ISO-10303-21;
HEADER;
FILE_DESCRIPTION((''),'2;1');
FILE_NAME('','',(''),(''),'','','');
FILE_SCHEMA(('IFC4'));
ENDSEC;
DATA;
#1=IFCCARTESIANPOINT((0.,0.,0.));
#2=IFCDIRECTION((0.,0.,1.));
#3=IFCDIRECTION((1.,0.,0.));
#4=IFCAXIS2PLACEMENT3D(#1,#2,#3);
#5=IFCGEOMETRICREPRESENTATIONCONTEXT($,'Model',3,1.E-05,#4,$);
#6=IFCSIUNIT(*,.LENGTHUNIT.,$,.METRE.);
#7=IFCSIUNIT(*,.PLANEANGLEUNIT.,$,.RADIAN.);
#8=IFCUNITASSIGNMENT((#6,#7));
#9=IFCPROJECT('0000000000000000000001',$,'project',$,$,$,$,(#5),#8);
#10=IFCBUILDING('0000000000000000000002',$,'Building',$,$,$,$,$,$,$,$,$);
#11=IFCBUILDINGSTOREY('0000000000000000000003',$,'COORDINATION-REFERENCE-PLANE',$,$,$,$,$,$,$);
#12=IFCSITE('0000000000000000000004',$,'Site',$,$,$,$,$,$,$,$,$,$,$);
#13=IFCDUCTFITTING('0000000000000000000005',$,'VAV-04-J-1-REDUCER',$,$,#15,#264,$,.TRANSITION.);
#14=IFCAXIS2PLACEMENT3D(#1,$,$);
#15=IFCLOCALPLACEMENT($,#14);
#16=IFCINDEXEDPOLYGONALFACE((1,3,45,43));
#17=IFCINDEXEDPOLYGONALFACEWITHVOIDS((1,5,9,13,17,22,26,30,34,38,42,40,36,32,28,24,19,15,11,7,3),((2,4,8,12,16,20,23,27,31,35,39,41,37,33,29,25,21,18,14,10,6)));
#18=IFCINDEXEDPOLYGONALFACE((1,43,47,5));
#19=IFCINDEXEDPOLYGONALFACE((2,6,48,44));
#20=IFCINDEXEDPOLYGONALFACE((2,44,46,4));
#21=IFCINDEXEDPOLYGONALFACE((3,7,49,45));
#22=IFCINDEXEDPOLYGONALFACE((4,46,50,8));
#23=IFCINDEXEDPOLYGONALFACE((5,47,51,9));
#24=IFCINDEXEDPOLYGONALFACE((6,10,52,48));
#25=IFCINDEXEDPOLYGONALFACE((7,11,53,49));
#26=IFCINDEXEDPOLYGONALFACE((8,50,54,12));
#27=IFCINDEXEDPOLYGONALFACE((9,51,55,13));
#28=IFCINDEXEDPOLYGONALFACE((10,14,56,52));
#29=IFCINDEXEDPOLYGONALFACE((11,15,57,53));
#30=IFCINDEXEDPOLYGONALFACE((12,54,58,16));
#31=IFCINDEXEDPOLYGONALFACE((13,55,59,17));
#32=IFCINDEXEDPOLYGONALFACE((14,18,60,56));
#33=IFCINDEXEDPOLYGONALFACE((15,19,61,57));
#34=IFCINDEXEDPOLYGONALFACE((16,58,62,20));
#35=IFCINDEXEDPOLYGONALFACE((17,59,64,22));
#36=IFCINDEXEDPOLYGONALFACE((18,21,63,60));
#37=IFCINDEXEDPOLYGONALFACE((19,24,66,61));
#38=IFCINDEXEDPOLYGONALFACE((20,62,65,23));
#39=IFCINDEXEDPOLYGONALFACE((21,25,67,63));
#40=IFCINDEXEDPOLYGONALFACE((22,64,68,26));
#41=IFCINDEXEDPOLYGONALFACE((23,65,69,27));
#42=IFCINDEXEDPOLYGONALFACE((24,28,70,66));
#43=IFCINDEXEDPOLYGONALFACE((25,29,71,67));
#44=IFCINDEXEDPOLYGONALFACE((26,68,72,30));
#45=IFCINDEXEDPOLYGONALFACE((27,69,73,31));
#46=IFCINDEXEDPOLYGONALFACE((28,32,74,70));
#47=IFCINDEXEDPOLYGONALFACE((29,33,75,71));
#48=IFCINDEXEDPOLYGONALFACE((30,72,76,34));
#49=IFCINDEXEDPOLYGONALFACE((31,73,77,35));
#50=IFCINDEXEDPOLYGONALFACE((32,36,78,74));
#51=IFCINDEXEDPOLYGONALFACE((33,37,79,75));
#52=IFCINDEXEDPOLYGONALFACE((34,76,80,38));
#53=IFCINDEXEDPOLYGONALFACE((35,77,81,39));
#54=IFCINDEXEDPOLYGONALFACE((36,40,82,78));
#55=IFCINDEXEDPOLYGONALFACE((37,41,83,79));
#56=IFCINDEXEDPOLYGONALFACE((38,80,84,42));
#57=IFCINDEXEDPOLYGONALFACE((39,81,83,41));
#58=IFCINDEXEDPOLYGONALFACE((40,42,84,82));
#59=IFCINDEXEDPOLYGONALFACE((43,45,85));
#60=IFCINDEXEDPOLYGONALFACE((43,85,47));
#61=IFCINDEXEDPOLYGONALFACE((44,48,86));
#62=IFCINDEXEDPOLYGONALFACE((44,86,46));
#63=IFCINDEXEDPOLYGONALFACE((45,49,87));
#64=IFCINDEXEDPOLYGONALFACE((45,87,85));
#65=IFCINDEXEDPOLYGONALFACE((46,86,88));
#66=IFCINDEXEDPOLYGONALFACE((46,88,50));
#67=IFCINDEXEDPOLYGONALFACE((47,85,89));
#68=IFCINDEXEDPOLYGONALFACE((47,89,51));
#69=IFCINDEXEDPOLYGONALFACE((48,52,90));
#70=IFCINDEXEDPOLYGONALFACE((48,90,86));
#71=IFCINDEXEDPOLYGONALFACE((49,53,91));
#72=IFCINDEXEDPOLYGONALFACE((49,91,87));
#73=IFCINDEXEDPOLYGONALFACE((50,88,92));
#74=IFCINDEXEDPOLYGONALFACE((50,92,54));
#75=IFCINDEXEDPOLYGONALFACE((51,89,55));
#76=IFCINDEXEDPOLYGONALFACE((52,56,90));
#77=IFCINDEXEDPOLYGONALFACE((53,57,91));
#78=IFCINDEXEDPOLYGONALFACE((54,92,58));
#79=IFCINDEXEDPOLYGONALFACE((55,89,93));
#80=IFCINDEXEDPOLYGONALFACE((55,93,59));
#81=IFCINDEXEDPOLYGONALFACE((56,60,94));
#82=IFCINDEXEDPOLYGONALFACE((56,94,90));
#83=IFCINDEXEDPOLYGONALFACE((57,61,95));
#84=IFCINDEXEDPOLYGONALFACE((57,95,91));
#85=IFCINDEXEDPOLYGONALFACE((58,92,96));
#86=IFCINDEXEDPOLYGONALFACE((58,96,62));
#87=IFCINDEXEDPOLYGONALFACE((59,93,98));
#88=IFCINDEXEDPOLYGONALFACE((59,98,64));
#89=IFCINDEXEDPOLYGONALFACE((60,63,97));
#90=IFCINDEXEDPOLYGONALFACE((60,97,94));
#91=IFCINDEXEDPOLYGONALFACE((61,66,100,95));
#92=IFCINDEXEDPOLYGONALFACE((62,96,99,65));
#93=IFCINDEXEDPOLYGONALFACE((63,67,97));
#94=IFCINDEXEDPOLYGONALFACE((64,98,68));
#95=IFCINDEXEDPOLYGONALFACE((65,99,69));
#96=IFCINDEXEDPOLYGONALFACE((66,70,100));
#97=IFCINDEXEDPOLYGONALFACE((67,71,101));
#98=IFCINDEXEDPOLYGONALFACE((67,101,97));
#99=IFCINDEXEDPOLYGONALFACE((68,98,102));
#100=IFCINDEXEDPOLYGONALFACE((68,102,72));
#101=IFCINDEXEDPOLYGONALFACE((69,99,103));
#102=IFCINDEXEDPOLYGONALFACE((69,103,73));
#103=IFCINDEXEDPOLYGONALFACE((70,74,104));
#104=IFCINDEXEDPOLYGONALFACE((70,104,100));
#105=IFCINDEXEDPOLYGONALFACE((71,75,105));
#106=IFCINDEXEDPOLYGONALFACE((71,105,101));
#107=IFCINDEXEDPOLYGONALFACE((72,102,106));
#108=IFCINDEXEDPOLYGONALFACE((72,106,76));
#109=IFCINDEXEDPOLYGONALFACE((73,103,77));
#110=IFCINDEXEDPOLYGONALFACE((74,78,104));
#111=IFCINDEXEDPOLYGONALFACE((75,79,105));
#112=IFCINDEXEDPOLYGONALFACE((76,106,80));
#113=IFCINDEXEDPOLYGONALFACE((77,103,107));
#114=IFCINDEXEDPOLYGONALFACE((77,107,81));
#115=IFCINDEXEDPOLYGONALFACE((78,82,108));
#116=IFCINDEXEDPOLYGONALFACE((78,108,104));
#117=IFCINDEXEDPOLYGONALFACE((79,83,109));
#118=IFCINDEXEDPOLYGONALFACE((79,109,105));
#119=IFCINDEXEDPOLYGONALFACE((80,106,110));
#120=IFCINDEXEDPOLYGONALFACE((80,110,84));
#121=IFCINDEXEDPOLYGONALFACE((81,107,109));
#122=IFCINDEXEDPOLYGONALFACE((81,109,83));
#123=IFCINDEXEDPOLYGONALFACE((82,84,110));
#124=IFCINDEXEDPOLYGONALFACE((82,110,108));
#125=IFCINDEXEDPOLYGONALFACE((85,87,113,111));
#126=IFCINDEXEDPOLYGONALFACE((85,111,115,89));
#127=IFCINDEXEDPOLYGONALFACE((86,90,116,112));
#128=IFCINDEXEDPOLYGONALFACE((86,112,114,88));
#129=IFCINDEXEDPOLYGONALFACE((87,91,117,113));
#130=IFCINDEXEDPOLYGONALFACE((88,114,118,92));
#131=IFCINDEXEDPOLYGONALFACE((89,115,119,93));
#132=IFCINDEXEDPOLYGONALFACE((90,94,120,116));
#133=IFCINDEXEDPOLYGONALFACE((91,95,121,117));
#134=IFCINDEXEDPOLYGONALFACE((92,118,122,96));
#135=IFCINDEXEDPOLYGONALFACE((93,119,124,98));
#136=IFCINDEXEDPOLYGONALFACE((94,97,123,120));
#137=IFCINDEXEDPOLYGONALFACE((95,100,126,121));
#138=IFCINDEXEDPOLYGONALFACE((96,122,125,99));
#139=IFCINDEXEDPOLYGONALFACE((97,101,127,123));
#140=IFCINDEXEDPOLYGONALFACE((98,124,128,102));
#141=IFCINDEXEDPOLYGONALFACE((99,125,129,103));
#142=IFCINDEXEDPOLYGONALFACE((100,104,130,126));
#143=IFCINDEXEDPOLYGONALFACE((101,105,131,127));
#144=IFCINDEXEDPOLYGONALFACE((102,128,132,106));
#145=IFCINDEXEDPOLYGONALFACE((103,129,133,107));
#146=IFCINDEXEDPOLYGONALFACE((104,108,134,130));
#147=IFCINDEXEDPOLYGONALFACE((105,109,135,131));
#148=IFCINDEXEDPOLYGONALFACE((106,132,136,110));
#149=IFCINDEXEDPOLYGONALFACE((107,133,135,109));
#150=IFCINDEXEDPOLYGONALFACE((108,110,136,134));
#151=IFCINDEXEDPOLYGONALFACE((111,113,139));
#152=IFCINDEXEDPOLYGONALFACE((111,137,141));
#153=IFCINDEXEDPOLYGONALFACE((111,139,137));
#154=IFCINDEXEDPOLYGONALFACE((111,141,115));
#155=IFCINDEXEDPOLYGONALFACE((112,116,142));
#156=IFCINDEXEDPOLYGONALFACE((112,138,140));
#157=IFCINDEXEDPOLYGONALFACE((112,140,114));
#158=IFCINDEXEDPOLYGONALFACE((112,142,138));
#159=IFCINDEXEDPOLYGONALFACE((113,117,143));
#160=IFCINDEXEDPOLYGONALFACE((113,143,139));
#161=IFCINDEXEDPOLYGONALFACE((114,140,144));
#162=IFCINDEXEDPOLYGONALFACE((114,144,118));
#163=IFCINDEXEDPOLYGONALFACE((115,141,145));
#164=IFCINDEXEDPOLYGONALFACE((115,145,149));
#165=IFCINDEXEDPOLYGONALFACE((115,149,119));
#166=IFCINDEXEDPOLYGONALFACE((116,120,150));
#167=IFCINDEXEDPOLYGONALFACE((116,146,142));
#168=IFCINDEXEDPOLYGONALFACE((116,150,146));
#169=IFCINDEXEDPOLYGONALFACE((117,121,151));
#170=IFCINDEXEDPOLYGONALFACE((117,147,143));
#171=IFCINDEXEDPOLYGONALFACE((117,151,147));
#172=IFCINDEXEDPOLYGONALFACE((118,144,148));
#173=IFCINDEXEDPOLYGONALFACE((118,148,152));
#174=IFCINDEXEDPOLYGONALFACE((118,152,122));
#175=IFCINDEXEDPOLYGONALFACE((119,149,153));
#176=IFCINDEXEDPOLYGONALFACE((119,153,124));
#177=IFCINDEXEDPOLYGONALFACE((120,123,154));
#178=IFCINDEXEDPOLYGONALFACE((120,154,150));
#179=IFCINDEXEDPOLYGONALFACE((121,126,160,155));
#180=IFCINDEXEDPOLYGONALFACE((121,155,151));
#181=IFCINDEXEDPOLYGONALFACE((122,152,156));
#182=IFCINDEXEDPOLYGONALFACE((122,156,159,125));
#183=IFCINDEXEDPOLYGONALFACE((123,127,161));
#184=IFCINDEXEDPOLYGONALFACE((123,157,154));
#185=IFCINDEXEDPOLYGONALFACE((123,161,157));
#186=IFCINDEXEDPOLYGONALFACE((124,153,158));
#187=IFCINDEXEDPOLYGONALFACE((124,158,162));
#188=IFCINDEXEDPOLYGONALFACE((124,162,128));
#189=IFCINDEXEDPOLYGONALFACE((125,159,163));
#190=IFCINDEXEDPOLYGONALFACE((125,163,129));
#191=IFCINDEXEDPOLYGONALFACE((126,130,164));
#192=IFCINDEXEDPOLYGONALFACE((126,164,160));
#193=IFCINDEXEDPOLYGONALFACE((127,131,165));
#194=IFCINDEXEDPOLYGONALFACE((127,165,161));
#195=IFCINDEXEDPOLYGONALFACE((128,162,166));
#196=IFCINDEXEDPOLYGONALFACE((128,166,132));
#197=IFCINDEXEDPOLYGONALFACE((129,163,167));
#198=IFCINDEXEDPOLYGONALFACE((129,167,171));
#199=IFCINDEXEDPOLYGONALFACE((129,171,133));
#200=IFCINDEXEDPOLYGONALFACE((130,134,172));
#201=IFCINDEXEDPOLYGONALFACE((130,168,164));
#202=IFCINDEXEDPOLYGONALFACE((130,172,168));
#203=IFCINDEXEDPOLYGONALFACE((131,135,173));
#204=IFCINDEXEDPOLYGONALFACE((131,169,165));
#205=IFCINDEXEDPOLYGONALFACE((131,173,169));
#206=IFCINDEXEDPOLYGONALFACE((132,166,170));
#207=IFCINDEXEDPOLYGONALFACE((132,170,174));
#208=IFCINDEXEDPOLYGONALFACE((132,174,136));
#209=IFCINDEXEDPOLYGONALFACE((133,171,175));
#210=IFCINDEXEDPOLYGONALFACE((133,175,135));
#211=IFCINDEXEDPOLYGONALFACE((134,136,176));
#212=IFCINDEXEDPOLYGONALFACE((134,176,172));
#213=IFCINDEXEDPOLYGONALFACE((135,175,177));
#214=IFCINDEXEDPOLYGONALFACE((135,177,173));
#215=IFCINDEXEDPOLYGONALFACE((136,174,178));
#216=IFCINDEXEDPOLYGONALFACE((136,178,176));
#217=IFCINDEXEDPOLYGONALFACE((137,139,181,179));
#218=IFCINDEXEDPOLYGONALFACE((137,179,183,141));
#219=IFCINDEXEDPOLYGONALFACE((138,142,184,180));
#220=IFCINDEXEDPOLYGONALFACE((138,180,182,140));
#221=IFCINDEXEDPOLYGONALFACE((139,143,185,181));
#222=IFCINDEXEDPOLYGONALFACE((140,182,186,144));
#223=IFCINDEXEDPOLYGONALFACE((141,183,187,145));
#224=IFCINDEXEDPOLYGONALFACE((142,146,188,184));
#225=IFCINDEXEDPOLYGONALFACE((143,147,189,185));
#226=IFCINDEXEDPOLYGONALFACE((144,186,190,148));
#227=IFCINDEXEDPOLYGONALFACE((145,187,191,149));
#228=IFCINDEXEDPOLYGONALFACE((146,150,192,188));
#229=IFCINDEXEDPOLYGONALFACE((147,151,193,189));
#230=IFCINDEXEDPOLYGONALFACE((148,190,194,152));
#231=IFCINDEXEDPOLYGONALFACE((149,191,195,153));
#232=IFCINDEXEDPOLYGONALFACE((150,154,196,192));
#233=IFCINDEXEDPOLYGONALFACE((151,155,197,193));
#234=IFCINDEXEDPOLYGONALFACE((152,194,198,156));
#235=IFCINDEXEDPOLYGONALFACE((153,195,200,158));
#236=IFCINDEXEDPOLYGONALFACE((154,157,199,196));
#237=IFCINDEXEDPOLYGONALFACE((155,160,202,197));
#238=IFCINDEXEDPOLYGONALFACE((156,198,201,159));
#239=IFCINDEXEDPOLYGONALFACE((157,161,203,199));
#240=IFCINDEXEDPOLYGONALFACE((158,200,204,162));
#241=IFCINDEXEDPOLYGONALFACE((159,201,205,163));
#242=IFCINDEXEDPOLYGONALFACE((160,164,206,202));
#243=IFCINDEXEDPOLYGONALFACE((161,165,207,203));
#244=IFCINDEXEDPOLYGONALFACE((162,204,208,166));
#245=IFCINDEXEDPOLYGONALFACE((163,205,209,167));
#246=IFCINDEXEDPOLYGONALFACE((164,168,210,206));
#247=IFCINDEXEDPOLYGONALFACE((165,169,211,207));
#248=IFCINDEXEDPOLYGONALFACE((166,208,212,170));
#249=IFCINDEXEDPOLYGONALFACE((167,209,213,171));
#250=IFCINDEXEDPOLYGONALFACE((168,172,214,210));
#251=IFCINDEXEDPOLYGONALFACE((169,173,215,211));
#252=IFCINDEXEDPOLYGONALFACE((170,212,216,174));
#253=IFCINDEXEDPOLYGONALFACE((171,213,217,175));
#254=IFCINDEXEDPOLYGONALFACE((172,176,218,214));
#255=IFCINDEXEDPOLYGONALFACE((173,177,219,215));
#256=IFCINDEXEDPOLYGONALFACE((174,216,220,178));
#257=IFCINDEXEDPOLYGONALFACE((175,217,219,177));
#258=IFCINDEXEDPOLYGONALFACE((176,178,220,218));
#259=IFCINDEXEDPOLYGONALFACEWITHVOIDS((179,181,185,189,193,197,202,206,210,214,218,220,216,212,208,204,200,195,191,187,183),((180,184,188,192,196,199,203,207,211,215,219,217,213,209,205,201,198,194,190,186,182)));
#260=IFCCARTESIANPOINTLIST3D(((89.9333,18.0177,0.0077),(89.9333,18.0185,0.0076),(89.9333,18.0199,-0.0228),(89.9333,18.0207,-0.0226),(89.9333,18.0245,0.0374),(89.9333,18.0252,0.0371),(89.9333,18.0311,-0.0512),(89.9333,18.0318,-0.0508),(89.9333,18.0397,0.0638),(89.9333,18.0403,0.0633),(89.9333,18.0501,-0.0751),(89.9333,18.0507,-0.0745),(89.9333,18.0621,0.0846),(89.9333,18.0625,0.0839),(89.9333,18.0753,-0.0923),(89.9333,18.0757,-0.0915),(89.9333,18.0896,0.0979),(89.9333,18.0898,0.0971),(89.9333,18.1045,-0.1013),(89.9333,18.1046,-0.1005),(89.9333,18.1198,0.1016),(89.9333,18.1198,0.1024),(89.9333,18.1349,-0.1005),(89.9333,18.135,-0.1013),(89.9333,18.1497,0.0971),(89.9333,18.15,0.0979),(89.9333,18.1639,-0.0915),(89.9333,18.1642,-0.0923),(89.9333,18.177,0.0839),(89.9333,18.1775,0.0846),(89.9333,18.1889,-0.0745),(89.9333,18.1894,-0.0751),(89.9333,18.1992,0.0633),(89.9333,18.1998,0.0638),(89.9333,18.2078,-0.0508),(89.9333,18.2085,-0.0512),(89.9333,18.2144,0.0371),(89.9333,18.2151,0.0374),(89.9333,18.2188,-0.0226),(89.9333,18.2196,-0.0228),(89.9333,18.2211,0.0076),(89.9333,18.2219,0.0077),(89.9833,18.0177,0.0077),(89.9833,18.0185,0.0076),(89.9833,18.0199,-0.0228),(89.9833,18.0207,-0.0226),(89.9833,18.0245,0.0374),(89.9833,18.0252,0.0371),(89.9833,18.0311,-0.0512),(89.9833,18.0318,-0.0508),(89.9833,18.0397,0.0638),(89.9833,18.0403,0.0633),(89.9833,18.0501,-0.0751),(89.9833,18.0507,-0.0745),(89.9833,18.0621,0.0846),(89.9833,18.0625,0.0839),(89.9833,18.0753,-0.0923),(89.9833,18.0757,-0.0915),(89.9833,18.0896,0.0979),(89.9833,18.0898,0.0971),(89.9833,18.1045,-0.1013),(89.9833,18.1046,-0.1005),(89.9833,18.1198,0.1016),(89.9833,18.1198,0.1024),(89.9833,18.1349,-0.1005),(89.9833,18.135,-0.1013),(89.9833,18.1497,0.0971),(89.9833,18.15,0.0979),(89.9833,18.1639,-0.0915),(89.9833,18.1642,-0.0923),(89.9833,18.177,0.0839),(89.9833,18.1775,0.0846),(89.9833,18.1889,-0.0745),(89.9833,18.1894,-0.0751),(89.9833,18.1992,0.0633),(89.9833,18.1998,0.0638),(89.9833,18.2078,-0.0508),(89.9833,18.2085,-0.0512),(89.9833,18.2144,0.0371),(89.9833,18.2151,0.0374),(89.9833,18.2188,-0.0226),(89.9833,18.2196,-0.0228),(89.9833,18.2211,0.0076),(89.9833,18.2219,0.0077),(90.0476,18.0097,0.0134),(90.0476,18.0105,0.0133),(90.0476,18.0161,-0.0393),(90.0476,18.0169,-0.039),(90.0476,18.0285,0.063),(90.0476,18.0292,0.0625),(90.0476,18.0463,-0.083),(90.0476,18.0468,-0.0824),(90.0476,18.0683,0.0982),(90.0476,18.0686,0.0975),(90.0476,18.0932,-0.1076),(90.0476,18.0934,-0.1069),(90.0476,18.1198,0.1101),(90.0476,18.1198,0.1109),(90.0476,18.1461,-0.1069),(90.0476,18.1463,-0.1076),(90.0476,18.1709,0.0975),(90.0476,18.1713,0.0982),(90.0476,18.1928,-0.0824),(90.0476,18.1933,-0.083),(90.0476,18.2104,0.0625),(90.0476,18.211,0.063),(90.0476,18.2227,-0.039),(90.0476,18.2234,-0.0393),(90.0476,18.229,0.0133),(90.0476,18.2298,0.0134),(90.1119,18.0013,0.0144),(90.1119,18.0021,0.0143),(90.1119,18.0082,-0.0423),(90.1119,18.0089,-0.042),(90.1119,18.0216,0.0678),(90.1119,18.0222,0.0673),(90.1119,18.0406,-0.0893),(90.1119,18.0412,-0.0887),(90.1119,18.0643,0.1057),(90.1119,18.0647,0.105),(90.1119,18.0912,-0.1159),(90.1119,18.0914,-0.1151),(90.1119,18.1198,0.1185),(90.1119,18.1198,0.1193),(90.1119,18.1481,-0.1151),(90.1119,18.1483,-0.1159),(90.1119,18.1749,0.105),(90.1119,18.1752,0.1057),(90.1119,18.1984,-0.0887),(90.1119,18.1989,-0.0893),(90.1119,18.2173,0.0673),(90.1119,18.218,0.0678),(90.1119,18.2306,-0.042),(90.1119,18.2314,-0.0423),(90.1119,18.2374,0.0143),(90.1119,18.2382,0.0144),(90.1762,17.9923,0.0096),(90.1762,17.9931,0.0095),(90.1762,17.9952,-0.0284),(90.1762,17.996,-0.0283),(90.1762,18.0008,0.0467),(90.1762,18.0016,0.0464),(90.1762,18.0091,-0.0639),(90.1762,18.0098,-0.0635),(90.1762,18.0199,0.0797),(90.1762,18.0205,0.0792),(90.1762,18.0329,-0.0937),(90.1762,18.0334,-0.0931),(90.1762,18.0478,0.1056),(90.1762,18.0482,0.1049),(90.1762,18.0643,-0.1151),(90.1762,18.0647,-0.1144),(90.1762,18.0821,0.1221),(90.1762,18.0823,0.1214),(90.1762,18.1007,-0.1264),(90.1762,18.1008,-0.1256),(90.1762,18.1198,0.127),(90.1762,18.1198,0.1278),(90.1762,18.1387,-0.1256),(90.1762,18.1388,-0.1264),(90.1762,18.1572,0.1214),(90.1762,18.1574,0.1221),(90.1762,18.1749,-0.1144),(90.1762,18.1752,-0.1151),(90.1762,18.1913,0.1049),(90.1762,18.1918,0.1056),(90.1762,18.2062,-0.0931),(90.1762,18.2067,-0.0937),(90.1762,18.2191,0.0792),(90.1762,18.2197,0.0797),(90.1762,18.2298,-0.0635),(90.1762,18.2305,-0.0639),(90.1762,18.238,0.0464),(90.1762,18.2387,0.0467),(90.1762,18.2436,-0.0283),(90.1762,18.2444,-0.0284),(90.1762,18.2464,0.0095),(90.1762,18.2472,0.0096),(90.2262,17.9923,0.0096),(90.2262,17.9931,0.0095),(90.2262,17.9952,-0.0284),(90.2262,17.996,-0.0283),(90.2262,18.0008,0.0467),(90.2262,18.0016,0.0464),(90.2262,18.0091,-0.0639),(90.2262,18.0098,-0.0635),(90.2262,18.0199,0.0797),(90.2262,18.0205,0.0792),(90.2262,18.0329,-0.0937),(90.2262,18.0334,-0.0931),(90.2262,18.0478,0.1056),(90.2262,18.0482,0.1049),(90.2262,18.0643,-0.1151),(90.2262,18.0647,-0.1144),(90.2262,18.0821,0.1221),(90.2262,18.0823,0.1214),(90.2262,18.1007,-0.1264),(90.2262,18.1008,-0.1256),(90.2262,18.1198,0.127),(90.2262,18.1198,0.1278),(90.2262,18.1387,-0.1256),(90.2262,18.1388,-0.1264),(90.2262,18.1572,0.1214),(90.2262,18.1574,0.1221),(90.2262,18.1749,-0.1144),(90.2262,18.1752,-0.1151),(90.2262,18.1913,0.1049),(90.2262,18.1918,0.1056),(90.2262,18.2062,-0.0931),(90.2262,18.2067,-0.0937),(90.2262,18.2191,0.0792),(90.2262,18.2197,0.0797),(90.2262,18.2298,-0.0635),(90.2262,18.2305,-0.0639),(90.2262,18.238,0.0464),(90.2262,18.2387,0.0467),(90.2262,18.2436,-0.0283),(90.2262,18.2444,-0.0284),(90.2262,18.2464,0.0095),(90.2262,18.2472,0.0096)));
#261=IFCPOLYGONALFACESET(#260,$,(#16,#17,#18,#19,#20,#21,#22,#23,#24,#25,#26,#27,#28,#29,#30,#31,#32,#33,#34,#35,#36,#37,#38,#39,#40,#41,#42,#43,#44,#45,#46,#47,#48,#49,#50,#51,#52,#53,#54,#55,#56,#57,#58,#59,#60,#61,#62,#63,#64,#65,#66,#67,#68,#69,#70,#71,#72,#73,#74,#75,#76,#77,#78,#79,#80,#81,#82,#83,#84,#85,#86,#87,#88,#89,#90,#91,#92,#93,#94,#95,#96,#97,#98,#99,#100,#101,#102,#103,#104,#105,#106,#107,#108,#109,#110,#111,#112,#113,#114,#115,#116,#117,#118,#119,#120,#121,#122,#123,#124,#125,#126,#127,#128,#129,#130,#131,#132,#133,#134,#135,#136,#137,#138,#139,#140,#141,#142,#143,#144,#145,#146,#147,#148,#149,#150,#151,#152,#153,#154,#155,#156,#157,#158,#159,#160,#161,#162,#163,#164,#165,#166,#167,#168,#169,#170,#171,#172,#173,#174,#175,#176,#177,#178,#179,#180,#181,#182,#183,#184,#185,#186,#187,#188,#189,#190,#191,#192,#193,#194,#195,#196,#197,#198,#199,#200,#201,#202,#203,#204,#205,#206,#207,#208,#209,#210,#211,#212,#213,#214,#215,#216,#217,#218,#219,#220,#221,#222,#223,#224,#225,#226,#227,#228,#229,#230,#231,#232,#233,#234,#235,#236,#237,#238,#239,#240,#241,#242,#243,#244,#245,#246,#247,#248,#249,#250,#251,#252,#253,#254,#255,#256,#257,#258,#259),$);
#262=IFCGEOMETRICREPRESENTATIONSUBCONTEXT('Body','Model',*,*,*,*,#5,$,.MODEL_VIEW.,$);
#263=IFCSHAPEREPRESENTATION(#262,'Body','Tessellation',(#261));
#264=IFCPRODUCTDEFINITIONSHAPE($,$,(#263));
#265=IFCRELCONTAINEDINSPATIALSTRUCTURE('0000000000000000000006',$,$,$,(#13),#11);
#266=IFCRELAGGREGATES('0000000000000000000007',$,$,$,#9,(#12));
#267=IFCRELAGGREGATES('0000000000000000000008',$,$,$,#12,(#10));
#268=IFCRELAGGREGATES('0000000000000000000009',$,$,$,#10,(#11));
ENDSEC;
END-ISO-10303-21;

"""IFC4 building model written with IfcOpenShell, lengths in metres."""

from ifc_helpers import new_model, entity, si_unit, frame, origin_with_axes, place, context, subcontext, project, spatial, element, save


model = new_model("IFC4")

# Units and contexts
model_context_1 = context("Model", 3, precision=1e-05, world=origin_with_axes())
body_context_1 = subcontext(model_context_1, "Body", "Model", "MODEL_VIEW")
ifc_project = project(units=[si_unit("LENGTHUNIT", "METRE"), si_unit("PLANEANGLEUNIT", "RADIAN")], contexts=[model_context_1])

# Site, building, storey
site = spatial("IfcSite", under=ifc_project, Name="Site")
building = spatial("IfcBuilding", under=site, Name="Building")
storey = spatial("IfcBuildingStorey", under=building, Name="COORDINATION-REFERENCE-PLANE")

# Duct fitting
for number, where, z_axis, x_axis, name in (
    (1, (90.2262, 18.1198, 0.0), (0.0, -1.0, 0.0), (0.0, 0.0, 1.0), "VAV-04-J-1-REDUCER"),
):
    element("IfcDuctFitting", number, at=place(None, frame(where, z_axis=z_axis, x_axis=x_axis)), inside=storey, Name=name, PredefinedType="TRANSITION", context=body_context_1, shape_type="SweptSolid", body=[
        entity("IfcRevolvedAreaSolid", entity("IfcArbitraryClosedProfileDef", "AREA", None, entity("IfcPolyline", [entity("IfcCartesianPoint", [0.1278, 0.0]), entity("IfcCartesianPoint", [0.1278, 0.05]), entity("IfcCartesianPoint", [0.1024, 0.2429]), entity("IfcCartesianPoint", [0.1024, 0.2929]), entity("IfcCartesianPoint", [0.1016, 0.2929]), entity("IfcCartesianPoint", [0.1016, 0.2429]), entity("IfcCartesianPoint", [0.127, 0.05]), entity("IfcCartesianPoint", [0.127, 0.0]), entity("IfcCartesianPoint", [0.1278, 0.0])])), entity("IfcAxis2Placement3D", entity("IfcCartesianPoint", [0.0, 0.0, 0.0])), entity("IfcAxis1Placement", entity("IfcCartesianPoint", [0.0, 0.0, 0.0]), entity("IfcDirection", [0.0, 1.0, 0.0])), 6.283185),
    ])

save(model, "model.ifc")
